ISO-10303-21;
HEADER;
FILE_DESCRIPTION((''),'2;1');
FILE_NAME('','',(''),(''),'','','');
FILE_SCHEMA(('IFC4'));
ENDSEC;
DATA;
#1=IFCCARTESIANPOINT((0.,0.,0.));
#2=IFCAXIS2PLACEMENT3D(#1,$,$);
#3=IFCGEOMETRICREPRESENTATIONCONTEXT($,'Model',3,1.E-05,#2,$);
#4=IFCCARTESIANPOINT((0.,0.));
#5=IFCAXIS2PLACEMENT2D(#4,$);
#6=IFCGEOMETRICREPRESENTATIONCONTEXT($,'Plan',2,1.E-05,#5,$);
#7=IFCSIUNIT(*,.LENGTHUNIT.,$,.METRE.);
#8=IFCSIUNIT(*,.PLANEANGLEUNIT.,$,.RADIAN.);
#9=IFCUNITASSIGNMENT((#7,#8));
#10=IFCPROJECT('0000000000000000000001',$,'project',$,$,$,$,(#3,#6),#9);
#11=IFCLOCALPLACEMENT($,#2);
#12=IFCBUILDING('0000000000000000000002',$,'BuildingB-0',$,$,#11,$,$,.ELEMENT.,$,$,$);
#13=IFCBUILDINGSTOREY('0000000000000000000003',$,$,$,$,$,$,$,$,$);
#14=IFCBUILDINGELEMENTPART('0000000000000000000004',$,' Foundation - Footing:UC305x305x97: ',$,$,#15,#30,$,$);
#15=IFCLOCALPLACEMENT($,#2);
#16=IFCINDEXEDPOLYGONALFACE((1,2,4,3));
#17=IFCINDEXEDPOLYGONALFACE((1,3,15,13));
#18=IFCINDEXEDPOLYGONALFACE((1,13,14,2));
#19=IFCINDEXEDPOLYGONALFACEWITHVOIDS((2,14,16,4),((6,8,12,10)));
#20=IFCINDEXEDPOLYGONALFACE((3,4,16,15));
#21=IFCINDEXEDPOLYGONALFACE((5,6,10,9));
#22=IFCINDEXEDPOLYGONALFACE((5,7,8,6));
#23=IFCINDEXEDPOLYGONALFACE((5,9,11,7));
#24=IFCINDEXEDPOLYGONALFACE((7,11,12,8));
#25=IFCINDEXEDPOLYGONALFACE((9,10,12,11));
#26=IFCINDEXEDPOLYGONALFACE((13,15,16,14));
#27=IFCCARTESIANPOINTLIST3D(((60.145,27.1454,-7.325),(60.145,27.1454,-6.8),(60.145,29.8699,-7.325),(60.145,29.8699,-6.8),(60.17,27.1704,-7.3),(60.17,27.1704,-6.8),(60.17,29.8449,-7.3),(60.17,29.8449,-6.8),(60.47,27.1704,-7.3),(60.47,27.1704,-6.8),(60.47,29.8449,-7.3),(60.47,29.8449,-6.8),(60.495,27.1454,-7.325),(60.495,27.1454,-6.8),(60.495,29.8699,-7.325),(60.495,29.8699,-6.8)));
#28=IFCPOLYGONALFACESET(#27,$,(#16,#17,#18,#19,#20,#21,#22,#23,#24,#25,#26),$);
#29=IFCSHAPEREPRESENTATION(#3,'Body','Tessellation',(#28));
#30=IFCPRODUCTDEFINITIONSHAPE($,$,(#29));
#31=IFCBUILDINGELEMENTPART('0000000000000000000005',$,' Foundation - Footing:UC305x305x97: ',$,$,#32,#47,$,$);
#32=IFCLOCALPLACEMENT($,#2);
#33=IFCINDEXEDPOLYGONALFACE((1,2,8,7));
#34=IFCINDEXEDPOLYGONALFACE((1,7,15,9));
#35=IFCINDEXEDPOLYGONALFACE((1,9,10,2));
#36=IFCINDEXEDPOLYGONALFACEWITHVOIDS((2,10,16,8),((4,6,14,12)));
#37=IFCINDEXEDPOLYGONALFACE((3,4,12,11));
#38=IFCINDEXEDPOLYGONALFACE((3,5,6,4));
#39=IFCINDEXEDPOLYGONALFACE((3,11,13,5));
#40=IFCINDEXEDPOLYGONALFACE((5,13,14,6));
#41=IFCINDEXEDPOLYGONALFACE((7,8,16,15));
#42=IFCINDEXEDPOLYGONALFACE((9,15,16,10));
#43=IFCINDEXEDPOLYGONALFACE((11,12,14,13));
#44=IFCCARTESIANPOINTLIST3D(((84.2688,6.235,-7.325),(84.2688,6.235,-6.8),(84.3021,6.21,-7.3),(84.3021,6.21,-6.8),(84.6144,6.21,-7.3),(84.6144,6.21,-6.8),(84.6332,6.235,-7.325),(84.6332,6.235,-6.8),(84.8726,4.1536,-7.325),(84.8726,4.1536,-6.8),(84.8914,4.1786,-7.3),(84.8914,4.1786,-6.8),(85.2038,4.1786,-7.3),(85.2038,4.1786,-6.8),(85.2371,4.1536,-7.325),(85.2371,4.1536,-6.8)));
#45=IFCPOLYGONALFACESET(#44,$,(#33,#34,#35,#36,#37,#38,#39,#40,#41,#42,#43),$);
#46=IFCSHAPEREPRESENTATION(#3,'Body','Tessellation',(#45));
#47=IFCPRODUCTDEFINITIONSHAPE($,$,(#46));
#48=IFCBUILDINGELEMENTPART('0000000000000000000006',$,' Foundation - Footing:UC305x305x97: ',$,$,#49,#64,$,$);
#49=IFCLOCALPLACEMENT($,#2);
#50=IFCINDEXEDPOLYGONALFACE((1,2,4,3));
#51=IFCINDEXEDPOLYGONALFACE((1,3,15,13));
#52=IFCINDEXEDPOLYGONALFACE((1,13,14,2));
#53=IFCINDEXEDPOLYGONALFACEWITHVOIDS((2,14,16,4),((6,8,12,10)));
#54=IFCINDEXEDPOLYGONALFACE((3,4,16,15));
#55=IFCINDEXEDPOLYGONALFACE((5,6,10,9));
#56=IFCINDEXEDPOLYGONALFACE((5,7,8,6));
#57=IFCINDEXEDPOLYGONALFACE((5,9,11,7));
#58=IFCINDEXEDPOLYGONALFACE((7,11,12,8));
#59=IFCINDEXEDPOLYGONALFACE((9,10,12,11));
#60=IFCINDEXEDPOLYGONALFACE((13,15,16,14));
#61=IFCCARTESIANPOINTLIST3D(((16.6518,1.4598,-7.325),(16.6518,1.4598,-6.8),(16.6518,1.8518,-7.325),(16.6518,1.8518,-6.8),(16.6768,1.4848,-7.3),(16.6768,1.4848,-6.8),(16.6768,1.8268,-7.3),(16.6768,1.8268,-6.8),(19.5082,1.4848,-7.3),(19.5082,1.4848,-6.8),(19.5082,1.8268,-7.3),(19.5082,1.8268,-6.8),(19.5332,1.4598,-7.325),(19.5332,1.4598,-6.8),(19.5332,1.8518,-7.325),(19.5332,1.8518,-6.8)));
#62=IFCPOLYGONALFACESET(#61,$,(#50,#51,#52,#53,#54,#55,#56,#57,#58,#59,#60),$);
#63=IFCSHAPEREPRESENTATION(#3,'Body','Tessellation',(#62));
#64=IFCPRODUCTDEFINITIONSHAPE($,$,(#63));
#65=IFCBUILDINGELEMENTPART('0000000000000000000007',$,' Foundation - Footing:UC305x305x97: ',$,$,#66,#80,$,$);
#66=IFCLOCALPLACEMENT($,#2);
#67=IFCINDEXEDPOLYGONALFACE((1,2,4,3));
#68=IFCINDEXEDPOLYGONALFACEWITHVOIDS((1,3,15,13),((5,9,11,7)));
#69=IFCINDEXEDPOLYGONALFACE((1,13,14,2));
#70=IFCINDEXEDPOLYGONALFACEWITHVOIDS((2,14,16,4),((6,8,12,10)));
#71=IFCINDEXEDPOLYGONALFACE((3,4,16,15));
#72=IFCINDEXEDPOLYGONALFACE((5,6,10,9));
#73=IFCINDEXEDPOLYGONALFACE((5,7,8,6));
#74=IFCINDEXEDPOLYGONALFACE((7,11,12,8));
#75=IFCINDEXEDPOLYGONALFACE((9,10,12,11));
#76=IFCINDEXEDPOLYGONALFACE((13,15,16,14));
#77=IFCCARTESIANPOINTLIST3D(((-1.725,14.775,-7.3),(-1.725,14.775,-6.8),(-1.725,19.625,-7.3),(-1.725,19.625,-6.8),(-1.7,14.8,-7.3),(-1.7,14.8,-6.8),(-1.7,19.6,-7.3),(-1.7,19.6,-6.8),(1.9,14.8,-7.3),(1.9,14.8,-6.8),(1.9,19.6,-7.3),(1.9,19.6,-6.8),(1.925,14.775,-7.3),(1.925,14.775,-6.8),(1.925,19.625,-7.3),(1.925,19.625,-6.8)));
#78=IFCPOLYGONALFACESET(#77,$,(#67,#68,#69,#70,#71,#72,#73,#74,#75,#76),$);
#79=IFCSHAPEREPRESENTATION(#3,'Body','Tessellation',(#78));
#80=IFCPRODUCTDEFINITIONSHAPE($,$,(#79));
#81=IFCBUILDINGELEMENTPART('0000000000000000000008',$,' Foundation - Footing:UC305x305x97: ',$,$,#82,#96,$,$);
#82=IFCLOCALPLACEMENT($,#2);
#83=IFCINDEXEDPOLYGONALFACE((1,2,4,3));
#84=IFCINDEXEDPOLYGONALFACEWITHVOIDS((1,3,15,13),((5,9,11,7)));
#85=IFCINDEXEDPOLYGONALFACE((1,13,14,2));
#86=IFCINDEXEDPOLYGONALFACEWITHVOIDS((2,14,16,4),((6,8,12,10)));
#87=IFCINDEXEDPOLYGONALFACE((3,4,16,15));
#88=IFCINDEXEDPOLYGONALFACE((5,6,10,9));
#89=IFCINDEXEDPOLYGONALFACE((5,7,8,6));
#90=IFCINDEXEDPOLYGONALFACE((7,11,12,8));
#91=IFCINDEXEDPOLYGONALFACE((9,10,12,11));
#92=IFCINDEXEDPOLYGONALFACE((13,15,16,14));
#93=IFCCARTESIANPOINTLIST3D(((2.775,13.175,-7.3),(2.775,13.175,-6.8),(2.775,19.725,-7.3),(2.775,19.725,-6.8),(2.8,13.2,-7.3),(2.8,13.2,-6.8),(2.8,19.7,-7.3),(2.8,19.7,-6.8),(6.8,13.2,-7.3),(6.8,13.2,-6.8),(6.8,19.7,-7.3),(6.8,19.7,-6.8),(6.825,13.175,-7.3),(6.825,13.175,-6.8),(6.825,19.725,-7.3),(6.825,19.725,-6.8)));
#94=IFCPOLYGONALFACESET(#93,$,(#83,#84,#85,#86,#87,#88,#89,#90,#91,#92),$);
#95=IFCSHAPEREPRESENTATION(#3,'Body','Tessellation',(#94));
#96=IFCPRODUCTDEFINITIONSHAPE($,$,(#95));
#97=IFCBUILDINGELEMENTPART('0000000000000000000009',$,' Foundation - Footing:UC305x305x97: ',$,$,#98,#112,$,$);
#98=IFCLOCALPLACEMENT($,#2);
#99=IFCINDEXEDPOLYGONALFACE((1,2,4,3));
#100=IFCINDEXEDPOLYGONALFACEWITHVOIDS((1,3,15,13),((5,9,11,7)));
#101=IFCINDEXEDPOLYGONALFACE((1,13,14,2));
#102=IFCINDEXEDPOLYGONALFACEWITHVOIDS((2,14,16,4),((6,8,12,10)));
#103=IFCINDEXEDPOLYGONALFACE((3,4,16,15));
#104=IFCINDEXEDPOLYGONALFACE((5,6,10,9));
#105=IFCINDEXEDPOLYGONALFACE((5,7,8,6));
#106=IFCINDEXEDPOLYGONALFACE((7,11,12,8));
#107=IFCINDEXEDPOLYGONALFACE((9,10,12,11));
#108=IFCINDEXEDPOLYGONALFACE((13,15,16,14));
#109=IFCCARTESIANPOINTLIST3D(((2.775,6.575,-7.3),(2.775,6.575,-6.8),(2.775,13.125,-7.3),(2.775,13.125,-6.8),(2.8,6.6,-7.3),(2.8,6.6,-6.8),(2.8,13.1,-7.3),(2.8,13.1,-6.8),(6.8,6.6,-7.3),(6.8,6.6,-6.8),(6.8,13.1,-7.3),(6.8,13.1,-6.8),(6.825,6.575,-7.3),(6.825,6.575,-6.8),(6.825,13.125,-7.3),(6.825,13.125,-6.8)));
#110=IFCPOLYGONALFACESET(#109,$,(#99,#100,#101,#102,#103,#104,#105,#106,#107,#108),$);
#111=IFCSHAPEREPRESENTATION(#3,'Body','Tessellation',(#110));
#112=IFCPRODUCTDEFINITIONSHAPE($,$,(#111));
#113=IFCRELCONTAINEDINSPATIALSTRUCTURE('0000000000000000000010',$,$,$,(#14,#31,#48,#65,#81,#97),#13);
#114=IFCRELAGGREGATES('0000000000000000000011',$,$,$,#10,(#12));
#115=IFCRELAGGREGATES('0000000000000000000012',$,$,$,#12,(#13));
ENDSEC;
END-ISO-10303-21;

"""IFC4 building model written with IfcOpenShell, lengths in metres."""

from ifc_helpers import new_model, si_unit, origin, origin_2d, place, context, project, spatial, polyline, outline, extrude, element, save


model = new_model("IFC4")

# Units and contexts
model_context = context("Model", 3, precision=1e-05, world=origin())
plan_context = context("Plan", 2, precision=1e-05, world=origin_2d())
ifc_project = project(units=[si_unit("LENGTHUNIT", "METRE"), si_unit("PLANEANGLEUNIT", "RADIAN")], contexts=[model_context, plan_context])

# Building, storey
building_placement = place(None, origin())
building = spatial("IfcBuilding", under=ifc_project, at=building_placement, Name="BuildingB-0", CompositionType="ELEMENT")
storey = spatial("IfcBuildingStorey", under=building)

# Building element parts, openings
building_element_part_1 = element("IfcBuildingElementPart", 1, inside=storey, Name=" Foundation - Footing:UC305x305x97: ", context=model_context, shape_type="SweptSolid", body=[
    extrude(outline(polyline([(60.495, 27.1454, -7.325), (60.145, 27.1454, -7.325), (60.145, 29.8699, -7.325), (60.495, 29.8699, -7.325), (60.495, 27.1454, -7.325)])), None, (0.0, 0.0, 1.0), 0.525),
])
element("IfcOpeningElement", 2, inside=storey, cuts=building_element_part_1, context=model_context, shape_type="SweptSolid", body=[
    extrude(outline(polyline([(60.47, 27.1704, -7.3), (60.17, 27.1704, -7.3), (60.17, 29.8449, -7.3), (60.47, 29.8449, -7.3), (60.47, 27.1704, -7.3)])), None, (0.0, 0.0, 1.0), 0.5),
])
building_element_part_2 = element("IfcBuildingElementPart", 3, inside=storey, Name=" Foundation - Footing:UC305x305x97: ", context=model_context, shape_type="SweptSolid", body=[
    extrude(outline(polyline([(84.8726, 4.1536, -7.325), (85.2371, 4.1536, -7.325), (84.6332, 6.235, -7.325), (84.2688, 6.235, -7.325), (84.8726, 4.1536, -7.325)])), None, (0.0, 0.0, 1.0), 0.525),
])
element("IfcOpeningElement", 4, inside=storey, cuts=building_element_part_2, context=model_context, shape_type="SweptSolid", body=[
    extrude(outline(polyline([(84.8914, 4.1786, -7.3), (85.2038, 4.1786, -7.3), (84.6144, 6.21, -7.3), (84.3021, 6.21, -7.3), (84.8914, 4.1786, -7.3)])), None, (0.0, 0.0, 1.0), 0.5),
])
building_element_part_3 = element("IfcBuildingElementPart", 5, inside=storey, Name=" Foundation - Footing:UC305x305x97: ", context=model_context, shape_type="SweptSolid", body=[
    extrude(outline(polyline([(16.6518, 1.4598, -7.325), (19.5332, 1.4598, -7.325), (19.5332, 1.8518, -7.325), (16.6518, 1.8518, -7.325), (16.6518, 1.4598, -7.325)])), None, (0.0, 0.0, 1.0), 0.525),
])
element("IfcOpeningElement", 6, inside=storey, cuts=building_element_part_3, context=model_context, shape_type="SweptSolid", body=[
    extrude(outline(polyline([(16.6768, 1.4848, -7.3), (19.5082, 1.4848, -7.3), (19.5082, 1.8268, -7.3), (16.6768, 1.8268, -7.3), (16.6768, 1.4848, -7.3)])), None, (0.0, 0.0, 1.0), 0.5),
])
building_element_part_4 = element("IfcBuildingElementPart", 7, inside=storey, Name=" Foundation - Footing:UC305x305x97: ", context=model_context, shape_type="SweptSolid", body=[
    extrude(outline(polyline([(1.925, 19.625, -7.3), (-1.725, 19.625, -7.3), (-1.725, 14.775, -7.3), (1.925, 14.775, -7.3), (1.925, 19.625, -7.3)])), None, (0.0, 0.0, 1.0), 0.5),
])
element("IfcOpeningElement", 8, inside=storey, cuts=building_element_part_4, context=model_context, shape_type="SweptSolid", body=[
    extrude(outline(polyline([(1.9, 19.6, -7.3), (-1.7, 19.6, -7.3), (-1.7, 14.8, -7.3), (1.9, 14.8, -7.3), (1.9, 19.6, -7.3)])), None, (0.0, 0.0, 1.0), 0.5),
])
building_element_part_5 = element("IfcBuildingElementPart", 9, inside=storey, Name=" Foundation - Footing:UC305x305x97: ", context=model_context, shape_type="SweptSolid", body=[
    extrude(outline(polyline([(6.825, 19.725, -7.3), (2.775, 19.725, -7.3), (2.775, 13.175, -7.3), (6.825, 13.175, -7.3), (6.825, 19.725, -7.3)])), None, (0.0, 0.0, 1.0), 0.5),
])
element("IfcOpeningElement", 10, inside=storey, cuts=building_element_part_5, context=model_context, shape_type="SweptSolid", body=[
    extrude(outline(polyline([(6.8, 19.7, -7.3), (2.8, 19.7, -7.3), (2.8, 13.2, -7.3), (6.8, 13.2, -7.3), (6.8, 19.7, -7.3)])), None, (0.0, 0.0, 1.0), 0.5),
])
building_element_part_6 = element("IfcBuildingElementPart", 11, inside=storey, Name=" Foundation - Footing:UC305x305x97: ", context=model_context, shape_type="SweptSolid", body=[
    extrude(outline(polyline([(6.825, 13.125, -7.3), (2.775, 13.125, -7.3), (2.775, 6.575, -7.3), (6.825, 6.575, -7.3), (6.825, 13.125, -7.3)])), None, (0.0, 0.0, 1.0), 0.5),
])
element("IfcOpeningElement", 12, inside=storey, cuts=building_element_part_6, context=model_context, shape_type="SweptSolid", body=[
    extrude(outline(polyline([(6.8, 13.1, -7.3), (2.8, 13.1, -7.3), (2.8, 6.6, -7.3), (6.8, 6.6, -7.3), (6.8, 13.1, -7.3)])), None, (0.0, 0.0, 1.0), 0.5),
])

save(model, "model.ifc")
